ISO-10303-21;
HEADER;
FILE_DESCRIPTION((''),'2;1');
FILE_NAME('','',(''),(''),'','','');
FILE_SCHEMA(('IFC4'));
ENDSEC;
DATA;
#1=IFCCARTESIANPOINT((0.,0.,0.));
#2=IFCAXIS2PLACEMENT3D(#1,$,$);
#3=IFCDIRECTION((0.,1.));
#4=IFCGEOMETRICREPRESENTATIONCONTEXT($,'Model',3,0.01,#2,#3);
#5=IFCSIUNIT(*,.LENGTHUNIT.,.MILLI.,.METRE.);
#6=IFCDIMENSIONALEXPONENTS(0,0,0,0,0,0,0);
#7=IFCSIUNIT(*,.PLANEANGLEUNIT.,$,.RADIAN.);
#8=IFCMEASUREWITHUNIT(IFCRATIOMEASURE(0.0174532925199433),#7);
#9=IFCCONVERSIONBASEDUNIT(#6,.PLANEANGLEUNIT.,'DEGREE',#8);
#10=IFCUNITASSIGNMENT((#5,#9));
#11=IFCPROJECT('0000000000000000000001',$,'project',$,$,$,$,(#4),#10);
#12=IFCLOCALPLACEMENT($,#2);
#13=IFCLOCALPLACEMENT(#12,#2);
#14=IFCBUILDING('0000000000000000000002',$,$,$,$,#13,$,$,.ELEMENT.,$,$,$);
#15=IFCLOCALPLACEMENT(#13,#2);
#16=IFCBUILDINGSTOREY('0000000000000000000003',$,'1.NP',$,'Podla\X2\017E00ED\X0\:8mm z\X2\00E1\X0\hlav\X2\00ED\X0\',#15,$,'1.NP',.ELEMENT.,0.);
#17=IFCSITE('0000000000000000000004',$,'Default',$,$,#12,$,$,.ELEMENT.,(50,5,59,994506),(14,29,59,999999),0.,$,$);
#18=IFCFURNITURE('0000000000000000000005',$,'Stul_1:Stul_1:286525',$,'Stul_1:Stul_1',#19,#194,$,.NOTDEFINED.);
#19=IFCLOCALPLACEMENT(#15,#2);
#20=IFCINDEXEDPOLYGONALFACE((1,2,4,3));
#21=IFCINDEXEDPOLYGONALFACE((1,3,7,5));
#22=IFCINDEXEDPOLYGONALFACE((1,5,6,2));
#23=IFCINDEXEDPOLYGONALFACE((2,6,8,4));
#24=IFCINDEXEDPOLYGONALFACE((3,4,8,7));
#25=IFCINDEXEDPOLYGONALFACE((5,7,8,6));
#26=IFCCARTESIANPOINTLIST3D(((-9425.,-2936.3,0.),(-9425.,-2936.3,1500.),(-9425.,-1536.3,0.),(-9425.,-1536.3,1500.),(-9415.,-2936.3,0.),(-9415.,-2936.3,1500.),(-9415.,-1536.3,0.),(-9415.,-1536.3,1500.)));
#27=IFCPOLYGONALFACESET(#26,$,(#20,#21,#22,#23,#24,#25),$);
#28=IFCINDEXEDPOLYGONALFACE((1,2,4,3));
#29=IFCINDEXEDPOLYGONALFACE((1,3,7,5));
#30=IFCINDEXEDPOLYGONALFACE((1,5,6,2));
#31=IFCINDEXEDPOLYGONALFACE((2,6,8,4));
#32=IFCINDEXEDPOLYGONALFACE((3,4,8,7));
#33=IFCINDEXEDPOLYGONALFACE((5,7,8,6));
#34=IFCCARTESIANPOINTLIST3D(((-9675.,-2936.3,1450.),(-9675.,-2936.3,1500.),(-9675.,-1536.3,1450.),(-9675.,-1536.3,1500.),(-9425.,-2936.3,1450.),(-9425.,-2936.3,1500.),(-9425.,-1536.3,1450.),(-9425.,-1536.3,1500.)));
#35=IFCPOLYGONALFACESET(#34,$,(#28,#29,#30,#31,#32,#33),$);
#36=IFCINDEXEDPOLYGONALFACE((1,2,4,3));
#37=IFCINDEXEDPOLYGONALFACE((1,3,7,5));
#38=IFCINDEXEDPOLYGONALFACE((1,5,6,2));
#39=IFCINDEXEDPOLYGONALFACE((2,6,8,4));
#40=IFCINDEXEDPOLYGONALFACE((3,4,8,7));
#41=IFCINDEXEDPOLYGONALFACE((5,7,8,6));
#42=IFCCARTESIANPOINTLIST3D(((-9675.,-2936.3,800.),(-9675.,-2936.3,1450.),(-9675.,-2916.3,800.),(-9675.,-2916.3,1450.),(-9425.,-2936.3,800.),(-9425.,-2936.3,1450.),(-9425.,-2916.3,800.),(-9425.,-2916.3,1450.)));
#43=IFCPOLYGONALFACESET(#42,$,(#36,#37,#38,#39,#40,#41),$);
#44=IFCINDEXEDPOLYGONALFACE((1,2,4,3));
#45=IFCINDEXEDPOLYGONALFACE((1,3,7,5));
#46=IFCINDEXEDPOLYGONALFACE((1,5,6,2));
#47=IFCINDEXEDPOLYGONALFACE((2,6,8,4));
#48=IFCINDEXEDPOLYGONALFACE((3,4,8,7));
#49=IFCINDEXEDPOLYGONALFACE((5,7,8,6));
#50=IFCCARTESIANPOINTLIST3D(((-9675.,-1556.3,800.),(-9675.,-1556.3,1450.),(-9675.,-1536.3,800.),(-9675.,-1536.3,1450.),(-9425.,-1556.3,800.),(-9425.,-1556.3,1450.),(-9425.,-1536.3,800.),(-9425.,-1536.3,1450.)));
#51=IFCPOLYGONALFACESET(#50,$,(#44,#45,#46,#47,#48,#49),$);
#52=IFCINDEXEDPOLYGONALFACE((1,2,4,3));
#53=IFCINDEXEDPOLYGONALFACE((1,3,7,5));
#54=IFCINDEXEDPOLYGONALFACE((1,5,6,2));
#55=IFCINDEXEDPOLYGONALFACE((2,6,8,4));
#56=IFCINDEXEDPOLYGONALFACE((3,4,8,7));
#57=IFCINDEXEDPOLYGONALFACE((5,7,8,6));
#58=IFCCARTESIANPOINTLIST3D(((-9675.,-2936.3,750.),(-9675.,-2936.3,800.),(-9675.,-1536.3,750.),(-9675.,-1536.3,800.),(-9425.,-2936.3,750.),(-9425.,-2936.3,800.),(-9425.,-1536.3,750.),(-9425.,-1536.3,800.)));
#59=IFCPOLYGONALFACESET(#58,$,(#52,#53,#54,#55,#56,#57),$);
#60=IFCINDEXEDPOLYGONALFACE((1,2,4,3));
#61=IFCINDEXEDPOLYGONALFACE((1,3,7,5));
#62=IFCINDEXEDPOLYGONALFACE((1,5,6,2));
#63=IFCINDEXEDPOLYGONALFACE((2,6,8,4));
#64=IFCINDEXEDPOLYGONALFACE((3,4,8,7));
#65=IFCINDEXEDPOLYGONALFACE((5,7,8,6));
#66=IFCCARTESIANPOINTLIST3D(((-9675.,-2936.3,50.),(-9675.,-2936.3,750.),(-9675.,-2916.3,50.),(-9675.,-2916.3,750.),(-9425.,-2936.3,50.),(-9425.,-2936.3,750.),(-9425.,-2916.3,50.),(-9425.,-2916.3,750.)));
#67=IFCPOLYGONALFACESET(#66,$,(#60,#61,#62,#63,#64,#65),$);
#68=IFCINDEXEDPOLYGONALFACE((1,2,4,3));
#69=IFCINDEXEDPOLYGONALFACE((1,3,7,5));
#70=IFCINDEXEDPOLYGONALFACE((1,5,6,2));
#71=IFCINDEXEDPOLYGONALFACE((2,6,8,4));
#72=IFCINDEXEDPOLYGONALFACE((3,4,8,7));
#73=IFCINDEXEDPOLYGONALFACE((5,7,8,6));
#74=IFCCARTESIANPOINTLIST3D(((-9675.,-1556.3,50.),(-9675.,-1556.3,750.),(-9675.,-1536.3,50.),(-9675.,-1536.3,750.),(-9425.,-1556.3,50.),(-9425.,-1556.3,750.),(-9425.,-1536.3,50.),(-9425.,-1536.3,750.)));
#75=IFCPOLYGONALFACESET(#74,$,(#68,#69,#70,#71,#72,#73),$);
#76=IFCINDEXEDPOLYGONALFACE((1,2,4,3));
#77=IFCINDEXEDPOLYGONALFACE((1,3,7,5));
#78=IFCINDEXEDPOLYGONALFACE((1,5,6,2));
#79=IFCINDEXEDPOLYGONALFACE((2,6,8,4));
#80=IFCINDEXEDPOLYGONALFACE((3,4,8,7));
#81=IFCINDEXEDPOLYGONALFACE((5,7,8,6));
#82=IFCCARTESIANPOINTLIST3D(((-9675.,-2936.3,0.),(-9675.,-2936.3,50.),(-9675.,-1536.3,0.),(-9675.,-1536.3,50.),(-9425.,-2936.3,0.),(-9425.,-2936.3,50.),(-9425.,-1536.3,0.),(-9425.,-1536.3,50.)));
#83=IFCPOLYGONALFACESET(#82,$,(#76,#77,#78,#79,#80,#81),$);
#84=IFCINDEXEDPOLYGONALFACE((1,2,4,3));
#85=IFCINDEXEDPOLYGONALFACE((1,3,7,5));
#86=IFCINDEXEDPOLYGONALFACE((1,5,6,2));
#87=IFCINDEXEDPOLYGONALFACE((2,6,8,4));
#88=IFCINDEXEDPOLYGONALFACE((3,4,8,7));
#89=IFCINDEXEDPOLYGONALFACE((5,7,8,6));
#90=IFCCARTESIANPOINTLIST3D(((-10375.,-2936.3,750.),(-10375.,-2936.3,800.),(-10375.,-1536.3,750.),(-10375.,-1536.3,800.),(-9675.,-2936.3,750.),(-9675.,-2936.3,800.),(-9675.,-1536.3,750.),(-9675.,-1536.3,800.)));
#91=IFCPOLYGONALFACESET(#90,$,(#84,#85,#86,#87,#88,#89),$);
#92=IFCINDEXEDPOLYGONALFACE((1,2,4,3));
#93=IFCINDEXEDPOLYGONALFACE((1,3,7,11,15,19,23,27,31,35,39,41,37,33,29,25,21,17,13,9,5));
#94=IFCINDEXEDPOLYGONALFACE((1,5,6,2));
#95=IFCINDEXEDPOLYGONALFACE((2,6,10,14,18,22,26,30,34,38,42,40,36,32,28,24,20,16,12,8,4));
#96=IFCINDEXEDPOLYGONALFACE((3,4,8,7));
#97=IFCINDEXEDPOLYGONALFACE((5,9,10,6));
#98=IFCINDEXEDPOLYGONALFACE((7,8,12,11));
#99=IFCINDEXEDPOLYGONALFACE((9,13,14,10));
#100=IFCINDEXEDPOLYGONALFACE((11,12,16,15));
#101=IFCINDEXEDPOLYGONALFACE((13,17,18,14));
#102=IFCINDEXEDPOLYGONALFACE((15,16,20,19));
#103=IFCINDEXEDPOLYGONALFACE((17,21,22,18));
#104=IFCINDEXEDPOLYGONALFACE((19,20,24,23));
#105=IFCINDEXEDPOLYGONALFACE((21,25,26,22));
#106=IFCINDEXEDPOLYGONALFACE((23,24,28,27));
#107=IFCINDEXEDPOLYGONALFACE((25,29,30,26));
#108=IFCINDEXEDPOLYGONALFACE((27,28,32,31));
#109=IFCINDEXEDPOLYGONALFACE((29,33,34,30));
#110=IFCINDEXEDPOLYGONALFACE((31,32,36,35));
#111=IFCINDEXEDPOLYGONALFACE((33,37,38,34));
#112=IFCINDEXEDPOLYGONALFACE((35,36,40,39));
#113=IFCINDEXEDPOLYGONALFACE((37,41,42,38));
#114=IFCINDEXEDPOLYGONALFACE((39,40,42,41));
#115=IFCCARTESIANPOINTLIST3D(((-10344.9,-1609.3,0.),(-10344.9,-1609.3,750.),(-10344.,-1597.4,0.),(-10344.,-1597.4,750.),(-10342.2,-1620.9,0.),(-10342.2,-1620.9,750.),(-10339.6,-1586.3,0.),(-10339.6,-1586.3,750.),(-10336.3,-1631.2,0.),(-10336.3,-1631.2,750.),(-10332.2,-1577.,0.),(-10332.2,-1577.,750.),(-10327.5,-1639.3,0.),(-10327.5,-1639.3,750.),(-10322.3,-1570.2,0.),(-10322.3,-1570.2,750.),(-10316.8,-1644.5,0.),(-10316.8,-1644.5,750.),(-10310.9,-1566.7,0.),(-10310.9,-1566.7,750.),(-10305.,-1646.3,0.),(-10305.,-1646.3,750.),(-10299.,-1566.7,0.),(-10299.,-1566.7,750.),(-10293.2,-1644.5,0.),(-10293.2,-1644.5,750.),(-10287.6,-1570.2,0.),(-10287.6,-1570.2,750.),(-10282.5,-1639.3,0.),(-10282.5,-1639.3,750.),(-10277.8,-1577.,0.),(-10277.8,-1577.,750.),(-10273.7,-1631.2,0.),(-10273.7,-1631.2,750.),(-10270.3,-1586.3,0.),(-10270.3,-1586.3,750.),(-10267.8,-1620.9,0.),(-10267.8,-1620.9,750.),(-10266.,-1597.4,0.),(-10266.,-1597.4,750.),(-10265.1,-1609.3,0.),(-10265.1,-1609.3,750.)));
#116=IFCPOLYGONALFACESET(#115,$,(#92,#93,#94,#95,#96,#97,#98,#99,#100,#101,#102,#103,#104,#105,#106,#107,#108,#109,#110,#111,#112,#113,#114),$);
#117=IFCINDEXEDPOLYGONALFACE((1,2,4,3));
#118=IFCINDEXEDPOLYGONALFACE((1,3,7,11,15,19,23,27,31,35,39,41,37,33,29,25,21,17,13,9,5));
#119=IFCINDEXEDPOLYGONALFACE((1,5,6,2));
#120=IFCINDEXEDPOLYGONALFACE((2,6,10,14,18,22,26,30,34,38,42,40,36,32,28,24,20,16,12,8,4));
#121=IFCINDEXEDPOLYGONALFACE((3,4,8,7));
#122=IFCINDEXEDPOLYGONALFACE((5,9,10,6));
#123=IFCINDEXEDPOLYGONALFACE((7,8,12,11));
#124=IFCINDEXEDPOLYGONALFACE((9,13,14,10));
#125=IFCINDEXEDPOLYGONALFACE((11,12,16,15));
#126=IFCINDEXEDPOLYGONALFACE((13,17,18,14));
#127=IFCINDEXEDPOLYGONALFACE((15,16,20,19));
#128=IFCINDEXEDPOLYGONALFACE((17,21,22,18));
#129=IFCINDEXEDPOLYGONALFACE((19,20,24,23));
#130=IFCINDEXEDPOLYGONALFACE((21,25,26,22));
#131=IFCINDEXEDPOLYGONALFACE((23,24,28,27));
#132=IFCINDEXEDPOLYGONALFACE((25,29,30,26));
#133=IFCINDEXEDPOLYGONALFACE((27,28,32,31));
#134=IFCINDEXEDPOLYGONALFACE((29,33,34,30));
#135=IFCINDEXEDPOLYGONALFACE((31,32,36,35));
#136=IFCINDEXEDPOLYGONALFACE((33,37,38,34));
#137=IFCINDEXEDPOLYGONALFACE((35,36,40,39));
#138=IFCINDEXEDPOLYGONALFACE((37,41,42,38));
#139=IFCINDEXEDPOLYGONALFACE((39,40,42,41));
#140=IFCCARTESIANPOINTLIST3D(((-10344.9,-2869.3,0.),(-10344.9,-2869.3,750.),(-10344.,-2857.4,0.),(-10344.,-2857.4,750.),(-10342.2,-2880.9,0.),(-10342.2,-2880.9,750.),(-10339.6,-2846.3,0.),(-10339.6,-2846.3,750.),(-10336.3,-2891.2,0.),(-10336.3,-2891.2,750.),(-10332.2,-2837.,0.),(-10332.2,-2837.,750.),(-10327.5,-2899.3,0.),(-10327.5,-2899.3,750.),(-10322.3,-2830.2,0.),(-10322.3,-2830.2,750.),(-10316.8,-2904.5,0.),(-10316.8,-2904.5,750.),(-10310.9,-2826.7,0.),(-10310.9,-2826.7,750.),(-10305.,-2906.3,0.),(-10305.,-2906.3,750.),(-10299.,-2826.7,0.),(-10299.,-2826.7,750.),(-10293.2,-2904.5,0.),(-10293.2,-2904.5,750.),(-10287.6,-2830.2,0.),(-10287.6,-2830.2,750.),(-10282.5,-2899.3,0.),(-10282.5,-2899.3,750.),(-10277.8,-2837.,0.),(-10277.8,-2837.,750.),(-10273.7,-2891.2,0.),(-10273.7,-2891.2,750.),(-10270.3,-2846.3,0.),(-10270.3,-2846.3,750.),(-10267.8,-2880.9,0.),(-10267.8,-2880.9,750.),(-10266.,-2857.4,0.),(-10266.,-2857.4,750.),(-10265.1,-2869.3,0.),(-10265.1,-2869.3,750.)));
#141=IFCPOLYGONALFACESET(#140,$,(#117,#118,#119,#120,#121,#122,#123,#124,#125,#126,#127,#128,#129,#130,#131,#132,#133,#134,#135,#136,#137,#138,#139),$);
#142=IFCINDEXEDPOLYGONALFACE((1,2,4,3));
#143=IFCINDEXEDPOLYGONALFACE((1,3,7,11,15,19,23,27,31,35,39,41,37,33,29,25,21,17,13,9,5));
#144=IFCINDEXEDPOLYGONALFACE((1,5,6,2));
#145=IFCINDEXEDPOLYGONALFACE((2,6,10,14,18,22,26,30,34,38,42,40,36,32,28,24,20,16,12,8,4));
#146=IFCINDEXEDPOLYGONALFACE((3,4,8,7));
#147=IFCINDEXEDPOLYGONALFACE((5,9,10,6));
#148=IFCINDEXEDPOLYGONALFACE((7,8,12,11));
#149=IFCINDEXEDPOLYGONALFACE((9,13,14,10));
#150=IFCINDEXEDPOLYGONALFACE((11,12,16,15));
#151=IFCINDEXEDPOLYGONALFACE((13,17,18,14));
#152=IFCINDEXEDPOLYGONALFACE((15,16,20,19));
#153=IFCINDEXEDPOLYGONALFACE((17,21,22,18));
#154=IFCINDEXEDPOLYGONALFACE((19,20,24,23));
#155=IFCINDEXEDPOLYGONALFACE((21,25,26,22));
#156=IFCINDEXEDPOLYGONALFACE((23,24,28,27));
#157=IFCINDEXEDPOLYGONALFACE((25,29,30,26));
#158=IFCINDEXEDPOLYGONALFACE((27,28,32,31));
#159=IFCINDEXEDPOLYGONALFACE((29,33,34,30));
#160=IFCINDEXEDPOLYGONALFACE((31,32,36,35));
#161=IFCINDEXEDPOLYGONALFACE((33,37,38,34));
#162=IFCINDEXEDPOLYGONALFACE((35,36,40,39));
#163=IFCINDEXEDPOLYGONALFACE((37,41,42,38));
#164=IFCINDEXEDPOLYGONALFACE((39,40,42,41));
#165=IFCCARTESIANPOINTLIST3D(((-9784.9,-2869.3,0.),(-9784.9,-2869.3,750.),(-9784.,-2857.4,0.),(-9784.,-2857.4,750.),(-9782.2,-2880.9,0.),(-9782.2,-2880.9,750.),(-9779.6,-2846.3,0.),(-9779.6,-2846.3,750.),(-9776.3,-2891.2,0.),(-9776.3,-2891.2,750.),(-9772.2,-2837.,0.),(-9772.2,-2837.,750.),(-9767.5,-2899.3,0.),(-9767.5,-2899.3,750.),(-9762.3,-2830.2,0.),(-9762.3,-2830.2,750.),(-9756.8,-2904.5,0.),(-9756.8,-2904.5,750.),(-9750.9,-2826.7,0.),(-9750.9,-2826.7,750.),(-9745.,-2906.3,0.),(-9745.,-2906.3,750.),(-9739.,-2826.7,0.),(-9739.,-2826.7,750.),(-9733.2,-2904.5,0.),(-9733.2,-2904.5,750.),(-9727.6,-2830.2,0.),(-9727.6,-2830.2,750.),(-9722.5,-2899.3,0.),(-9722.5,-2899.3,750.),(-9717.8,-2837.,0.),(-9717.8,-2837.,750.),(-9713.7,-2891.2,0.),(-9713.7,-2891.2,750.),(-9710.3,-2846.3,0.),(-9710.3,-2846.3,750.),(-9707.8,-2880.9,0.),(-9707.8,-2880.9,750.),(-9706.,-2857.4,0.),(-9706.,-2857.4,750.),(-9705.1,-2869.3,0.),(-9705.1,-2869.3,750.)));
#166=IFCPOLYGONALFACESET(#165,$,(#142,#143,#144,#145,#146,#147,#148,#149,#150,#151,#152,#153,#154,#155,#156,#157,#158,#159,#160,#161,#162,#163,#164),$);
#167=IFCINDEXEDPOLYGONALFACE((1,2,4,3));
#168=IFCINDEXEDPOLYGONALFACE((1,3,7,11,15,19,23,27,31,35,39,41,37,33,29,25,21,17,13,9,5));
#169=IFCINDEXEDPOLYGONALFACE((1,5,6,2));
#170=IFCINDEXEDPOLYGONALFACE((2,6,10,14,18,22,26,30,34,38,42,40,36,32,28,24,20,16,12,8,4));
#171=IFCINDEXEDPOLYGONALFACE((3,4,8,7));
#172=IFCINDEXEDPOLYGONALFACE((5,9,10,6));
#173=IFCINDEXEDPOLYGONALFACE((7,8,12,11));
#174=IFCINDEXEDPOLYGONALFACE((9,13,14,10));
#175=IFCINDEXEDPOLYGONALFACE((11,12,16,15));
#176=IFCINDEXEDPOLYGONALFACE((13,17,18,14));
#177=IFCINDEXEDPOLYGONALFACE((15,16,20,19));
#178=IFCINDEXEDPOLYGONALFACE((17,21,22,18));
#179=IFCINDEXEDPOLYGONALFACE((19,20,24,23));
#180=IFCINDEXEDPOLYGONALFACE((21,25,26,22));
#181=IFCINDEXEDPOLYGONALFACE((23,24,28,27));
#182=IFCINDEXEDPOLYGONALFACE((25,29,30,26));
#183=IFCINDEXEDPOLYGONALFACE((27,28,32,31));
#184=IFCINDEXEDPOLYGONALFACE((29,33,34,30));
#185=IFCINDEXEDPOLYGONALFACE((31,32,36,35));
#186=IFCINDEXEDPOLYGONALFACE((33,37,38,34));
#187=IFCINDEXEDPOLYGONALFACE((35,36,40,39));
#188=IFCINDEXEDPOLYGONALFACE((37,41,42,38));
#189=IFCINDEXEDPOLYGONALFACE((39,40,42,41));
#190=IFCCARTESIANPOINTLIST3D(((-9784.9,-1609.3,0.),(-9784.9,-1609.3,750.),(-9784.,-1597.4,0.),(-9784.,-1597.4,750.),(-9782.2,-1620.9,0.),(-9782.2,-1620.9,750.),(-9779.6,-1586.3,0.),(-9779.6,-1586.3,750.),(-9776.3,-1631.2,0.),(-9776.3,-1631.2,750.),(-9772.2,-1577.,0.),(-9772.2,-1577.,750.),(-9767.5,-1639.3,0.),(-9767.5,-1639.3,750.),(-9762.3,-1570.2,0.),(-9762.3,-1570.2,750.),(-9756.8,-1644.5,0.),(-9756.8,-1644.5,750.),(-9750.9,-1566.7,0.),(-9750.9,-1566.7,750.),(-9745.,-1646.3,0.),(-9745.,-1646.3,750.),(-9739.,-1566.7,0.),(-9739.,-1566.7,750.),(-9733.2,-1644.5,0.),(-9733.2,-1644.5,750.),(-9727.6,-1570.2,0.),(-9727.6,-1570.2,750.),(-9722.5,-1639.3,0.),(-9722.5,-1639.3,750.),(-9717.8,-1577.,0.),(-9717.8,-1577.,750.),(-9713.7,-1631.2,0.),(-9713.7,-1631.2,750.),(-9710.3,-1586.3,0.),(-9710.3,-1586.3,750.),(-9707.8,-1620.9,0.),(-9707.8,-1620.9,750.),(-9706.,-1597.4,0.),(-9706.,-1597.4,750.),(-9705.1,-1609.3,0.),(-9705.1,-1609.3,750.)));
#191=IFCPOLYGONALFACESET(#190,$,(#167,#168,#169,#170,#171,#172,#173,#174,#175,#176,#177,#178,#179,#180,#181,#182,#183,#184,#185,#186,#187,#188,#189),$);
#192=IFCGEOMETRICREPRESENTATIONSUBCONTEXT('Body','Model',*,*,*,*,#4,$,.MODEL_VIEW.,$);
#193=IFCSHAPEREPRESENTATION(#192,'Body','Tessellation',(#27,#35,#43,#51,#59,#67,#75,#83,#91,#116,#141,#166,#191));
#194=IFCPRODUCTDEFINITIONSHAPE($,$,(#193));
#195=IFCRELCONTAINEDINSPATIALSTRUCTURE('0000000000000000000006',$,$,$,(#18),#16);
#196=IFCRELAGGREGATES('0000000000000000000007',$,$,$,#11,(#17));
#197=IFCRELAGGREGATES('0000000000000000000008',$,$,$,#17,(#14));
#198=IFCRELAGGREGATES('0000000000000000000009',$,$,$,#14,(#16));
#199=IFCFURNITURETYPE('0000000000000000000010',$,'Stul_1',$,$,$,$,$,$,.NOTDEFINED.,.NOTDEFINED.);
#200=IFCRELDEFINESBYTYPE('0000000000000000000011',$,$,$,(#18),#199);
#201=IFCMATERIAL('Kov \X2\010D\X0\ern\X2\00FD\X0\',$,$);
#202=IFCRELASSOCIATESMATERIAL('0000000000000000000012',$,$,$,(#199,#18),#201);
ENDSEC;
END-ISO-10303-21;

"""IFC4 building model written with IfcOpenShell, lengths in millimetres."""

from ifc_helpers import new_model, entity, si_unit, converted_unit, direction, frame, frame_2d, origin, origin_2d_with_axis, place, context, subcontext, project, spatial, rectangle, circle, extrude, source, transform, mapped, material, type_object, type_shapes, element, save


model = new_model("IFC4")

# Units and contexts
model_context = context("Model", 3, precision=0.01, world=origin(), true_north=direction((0.0, 1.0)))
body_context = subcontext(model_context, "Body", "Model", "MODEL_VIEW")
ifc_project = project(units=[si_unit("LENGTHUNIT", "METRE", prefix="MILLI"), converted_unit("PLANEANGLEUNIT", "DEGREE", entity("IfcRatioMeasure", 0.0174532925199433), si_unit("PLANEANGLEUNIT", "RADIAN"), dimensions=[0, 0, 0, 0, 0, 0, 0])], contexts=[model_context])

# Site, building, storey
site_placement = place(None, origin())
site = spatial("IfcSite", under=ifc_project, at=site_placement, Name="Default", CompositionType="ELEMENT", RefLatitude=(50, 5, 59, 994506), RefLongitude=(14, 29, 59, 999999), RefElevation=0.0)
building_placement = place(site_placement, origin())
building = spatial("IfcBuilding", under=site, at=building_placement, CompositionType="ELEMENT")
storey_placement = place(building_placement, origin())
storey = spatial("IfcBuildingStorey", under=building, at=storey_placement, Name="1.NP", ObjectType="Podlaží:8mm záhlaví", LongName="1.NP", CompositionType="ELEMENT", Elevation=0.0)

# Furniture
ifc_material_1 = material(Name="Kov černý")
furniture_type = type_object("IfcFurnitureType", Name="Stul_1", AssemblyPlace="NOTDEFINED", PredefinedType="NOTDEFINED", material=ifc_material_1)
shared_shape_1 = source(origin(), body_context, "Body", "SweptSolid", [
    extrude(rectangle(XDim=1400.0, YDim=10.0, at=origin_2d_with_axis()), frame((0.0, 605.0, 0.0), z_axis=(0.0, 0.0, 1.0), x_axis=(-1.0, 0.0, 0.0)), (0.0, 0.0, 1.0), 1500.0),
    extrude(rectangle(XDim=1400.0, YDim=250.0, at=frame_2d((0.0, 0.0), x_axis=(1.0, 0.0))), frame((0.0, 475.0, 1450.0), z_axis=(0.0, 0.0, 1.0), x_axis=(-1.0, 0.0, 0.0)), (0.0, 0.0, 1.0), 50.0),
    extrude(rectangle(XDim=20.0, YDim=250.0, at=origin_2d_with_axis()), frame((690.0, 475.0, 800.0), z_axis=(0.0, 0.0, 1.0), x_axis=(-1.0, 0.0, 0.0)), (0.0, 0.0, 1.0), 650.0),
    extrude(rectangle(XDim=20.0, YDim=250.0, at=frame_2d((0.0, 0.0), x_axis=(1.0, 0.0))), frame((-690.0, 475.0, 800.0), z_axis=(0.0, 0.0, 1.0), x_axis=(-1.0, 0.0, 0.0)), (0.0, 0.0, 1.0), 650.0),
    extrude(rectangle(XDim=1400.0, YDim=250.0, at=origin_2d_with_axis()), frame((0.0, 475.0, 750.0), z_axis=(0.0, 0.0, 1.0), x_axis=(-1.0, 0.0, 0.0)), (0.0, 0.0, 1.0), 50.0),
    extrude(rectangle(XDim=20.0, YDim=250.0, at=origin_2d_with_axis()), frame((690.0, 475.0, 50.0), z_axis=(0.0, 0.0, 1.0), x_axis=(-1.0, 0.0, 0.0)), (0.0, 0.0, 1.0), 700.0),
    extrude(rectangle(XDim=20.0, YDim=250.0, at=frame_2d((0.0, 0.0), x_axis=(1.0, 0.0))), frame((-690.0, 475.0, 50.0), z_axis=(0.0, 0.0, 1.0), x_axis=(-1.0, 0.0, 0.0)), (0.0, 0.0, 1.0), 700.0),
    extrude(rectangle(XDim=1400.0, YDim=250.0, at=origin_2d_with_axis()), frame((0.0, 475.0, 0.0), z_axis=(0.0, 0.0, 1.0), x_axis=(-1.0, 0.0, 0.0)), (0.0, 0.0, 1.0), 50.0),
    extrude(rectangle(XDim=1400.0, YDim=700.0, at=origin_2d_with_axis()), frame((0.0, 0.0, 750.0), z_axis=(0.0, 0.0, 1.0), x_axis=(-1.0, 0.0, 0.0)), (0.0, 0.0, 1.0), 50.0),
    extrude(circle(Radius=40.0, at=frame_2d((0.0, 0.0), x_axis=(1.0, 0.0))), frame((-630.0, -280.0, 0.0)), (0.0, 0.0, 1.0), 750.0),
    extrude(circle(Radius=40.0, at=frame_2d((0.0, 0.0), x_axis=(1.0, 0.0))), frame((630.0, -280.0, 0.0)), (0.0, 0.0, 1.0), 750.0),
    extrude(circle(Radius=40.0, at=frame_2d((0.0, 0.0), x_axis=(1.0, 0.0))), frame((630.0, 280.0, 0.0)), (0.0, 0.0, 1.0), 750.0),
    extrude(circle(Radius=40.0, at=frame_2d((0.0, 0.0), x_axis=(1.0, 0.0))), frame((-630.0, 280.0, 0.0)), (0.0, 0.0, 1.0), 750.0),
])
type_shapes(furniture_type, [shared_shape_1])
for number, where, z_axis, x_axis, name in (
    (1, (-10025.0, -2236.3, 0.0), (0.0, 0.0, 1.0), (0.0, -1.0, 0.0), "Stul_1:Stul_1:286525"),
):
    element("IfcFurniture", number, at=place(storey_placement, frame(where, z_axis=z_axis, x_axis=x_axis)), inside=storey, type_object=furniture_type, material=ifc_material_1, Name=name, ObjectType="Stul_1:Stul_1", PredefinedType="NOTDEFINED", context=body_context, shape_type="MappedRepresentation", body=[
        mapped(shared_shape_1, transform((0.0, 0.0, 0.0), scale=1.0)),
    ])

save(model, "model.ifc")
